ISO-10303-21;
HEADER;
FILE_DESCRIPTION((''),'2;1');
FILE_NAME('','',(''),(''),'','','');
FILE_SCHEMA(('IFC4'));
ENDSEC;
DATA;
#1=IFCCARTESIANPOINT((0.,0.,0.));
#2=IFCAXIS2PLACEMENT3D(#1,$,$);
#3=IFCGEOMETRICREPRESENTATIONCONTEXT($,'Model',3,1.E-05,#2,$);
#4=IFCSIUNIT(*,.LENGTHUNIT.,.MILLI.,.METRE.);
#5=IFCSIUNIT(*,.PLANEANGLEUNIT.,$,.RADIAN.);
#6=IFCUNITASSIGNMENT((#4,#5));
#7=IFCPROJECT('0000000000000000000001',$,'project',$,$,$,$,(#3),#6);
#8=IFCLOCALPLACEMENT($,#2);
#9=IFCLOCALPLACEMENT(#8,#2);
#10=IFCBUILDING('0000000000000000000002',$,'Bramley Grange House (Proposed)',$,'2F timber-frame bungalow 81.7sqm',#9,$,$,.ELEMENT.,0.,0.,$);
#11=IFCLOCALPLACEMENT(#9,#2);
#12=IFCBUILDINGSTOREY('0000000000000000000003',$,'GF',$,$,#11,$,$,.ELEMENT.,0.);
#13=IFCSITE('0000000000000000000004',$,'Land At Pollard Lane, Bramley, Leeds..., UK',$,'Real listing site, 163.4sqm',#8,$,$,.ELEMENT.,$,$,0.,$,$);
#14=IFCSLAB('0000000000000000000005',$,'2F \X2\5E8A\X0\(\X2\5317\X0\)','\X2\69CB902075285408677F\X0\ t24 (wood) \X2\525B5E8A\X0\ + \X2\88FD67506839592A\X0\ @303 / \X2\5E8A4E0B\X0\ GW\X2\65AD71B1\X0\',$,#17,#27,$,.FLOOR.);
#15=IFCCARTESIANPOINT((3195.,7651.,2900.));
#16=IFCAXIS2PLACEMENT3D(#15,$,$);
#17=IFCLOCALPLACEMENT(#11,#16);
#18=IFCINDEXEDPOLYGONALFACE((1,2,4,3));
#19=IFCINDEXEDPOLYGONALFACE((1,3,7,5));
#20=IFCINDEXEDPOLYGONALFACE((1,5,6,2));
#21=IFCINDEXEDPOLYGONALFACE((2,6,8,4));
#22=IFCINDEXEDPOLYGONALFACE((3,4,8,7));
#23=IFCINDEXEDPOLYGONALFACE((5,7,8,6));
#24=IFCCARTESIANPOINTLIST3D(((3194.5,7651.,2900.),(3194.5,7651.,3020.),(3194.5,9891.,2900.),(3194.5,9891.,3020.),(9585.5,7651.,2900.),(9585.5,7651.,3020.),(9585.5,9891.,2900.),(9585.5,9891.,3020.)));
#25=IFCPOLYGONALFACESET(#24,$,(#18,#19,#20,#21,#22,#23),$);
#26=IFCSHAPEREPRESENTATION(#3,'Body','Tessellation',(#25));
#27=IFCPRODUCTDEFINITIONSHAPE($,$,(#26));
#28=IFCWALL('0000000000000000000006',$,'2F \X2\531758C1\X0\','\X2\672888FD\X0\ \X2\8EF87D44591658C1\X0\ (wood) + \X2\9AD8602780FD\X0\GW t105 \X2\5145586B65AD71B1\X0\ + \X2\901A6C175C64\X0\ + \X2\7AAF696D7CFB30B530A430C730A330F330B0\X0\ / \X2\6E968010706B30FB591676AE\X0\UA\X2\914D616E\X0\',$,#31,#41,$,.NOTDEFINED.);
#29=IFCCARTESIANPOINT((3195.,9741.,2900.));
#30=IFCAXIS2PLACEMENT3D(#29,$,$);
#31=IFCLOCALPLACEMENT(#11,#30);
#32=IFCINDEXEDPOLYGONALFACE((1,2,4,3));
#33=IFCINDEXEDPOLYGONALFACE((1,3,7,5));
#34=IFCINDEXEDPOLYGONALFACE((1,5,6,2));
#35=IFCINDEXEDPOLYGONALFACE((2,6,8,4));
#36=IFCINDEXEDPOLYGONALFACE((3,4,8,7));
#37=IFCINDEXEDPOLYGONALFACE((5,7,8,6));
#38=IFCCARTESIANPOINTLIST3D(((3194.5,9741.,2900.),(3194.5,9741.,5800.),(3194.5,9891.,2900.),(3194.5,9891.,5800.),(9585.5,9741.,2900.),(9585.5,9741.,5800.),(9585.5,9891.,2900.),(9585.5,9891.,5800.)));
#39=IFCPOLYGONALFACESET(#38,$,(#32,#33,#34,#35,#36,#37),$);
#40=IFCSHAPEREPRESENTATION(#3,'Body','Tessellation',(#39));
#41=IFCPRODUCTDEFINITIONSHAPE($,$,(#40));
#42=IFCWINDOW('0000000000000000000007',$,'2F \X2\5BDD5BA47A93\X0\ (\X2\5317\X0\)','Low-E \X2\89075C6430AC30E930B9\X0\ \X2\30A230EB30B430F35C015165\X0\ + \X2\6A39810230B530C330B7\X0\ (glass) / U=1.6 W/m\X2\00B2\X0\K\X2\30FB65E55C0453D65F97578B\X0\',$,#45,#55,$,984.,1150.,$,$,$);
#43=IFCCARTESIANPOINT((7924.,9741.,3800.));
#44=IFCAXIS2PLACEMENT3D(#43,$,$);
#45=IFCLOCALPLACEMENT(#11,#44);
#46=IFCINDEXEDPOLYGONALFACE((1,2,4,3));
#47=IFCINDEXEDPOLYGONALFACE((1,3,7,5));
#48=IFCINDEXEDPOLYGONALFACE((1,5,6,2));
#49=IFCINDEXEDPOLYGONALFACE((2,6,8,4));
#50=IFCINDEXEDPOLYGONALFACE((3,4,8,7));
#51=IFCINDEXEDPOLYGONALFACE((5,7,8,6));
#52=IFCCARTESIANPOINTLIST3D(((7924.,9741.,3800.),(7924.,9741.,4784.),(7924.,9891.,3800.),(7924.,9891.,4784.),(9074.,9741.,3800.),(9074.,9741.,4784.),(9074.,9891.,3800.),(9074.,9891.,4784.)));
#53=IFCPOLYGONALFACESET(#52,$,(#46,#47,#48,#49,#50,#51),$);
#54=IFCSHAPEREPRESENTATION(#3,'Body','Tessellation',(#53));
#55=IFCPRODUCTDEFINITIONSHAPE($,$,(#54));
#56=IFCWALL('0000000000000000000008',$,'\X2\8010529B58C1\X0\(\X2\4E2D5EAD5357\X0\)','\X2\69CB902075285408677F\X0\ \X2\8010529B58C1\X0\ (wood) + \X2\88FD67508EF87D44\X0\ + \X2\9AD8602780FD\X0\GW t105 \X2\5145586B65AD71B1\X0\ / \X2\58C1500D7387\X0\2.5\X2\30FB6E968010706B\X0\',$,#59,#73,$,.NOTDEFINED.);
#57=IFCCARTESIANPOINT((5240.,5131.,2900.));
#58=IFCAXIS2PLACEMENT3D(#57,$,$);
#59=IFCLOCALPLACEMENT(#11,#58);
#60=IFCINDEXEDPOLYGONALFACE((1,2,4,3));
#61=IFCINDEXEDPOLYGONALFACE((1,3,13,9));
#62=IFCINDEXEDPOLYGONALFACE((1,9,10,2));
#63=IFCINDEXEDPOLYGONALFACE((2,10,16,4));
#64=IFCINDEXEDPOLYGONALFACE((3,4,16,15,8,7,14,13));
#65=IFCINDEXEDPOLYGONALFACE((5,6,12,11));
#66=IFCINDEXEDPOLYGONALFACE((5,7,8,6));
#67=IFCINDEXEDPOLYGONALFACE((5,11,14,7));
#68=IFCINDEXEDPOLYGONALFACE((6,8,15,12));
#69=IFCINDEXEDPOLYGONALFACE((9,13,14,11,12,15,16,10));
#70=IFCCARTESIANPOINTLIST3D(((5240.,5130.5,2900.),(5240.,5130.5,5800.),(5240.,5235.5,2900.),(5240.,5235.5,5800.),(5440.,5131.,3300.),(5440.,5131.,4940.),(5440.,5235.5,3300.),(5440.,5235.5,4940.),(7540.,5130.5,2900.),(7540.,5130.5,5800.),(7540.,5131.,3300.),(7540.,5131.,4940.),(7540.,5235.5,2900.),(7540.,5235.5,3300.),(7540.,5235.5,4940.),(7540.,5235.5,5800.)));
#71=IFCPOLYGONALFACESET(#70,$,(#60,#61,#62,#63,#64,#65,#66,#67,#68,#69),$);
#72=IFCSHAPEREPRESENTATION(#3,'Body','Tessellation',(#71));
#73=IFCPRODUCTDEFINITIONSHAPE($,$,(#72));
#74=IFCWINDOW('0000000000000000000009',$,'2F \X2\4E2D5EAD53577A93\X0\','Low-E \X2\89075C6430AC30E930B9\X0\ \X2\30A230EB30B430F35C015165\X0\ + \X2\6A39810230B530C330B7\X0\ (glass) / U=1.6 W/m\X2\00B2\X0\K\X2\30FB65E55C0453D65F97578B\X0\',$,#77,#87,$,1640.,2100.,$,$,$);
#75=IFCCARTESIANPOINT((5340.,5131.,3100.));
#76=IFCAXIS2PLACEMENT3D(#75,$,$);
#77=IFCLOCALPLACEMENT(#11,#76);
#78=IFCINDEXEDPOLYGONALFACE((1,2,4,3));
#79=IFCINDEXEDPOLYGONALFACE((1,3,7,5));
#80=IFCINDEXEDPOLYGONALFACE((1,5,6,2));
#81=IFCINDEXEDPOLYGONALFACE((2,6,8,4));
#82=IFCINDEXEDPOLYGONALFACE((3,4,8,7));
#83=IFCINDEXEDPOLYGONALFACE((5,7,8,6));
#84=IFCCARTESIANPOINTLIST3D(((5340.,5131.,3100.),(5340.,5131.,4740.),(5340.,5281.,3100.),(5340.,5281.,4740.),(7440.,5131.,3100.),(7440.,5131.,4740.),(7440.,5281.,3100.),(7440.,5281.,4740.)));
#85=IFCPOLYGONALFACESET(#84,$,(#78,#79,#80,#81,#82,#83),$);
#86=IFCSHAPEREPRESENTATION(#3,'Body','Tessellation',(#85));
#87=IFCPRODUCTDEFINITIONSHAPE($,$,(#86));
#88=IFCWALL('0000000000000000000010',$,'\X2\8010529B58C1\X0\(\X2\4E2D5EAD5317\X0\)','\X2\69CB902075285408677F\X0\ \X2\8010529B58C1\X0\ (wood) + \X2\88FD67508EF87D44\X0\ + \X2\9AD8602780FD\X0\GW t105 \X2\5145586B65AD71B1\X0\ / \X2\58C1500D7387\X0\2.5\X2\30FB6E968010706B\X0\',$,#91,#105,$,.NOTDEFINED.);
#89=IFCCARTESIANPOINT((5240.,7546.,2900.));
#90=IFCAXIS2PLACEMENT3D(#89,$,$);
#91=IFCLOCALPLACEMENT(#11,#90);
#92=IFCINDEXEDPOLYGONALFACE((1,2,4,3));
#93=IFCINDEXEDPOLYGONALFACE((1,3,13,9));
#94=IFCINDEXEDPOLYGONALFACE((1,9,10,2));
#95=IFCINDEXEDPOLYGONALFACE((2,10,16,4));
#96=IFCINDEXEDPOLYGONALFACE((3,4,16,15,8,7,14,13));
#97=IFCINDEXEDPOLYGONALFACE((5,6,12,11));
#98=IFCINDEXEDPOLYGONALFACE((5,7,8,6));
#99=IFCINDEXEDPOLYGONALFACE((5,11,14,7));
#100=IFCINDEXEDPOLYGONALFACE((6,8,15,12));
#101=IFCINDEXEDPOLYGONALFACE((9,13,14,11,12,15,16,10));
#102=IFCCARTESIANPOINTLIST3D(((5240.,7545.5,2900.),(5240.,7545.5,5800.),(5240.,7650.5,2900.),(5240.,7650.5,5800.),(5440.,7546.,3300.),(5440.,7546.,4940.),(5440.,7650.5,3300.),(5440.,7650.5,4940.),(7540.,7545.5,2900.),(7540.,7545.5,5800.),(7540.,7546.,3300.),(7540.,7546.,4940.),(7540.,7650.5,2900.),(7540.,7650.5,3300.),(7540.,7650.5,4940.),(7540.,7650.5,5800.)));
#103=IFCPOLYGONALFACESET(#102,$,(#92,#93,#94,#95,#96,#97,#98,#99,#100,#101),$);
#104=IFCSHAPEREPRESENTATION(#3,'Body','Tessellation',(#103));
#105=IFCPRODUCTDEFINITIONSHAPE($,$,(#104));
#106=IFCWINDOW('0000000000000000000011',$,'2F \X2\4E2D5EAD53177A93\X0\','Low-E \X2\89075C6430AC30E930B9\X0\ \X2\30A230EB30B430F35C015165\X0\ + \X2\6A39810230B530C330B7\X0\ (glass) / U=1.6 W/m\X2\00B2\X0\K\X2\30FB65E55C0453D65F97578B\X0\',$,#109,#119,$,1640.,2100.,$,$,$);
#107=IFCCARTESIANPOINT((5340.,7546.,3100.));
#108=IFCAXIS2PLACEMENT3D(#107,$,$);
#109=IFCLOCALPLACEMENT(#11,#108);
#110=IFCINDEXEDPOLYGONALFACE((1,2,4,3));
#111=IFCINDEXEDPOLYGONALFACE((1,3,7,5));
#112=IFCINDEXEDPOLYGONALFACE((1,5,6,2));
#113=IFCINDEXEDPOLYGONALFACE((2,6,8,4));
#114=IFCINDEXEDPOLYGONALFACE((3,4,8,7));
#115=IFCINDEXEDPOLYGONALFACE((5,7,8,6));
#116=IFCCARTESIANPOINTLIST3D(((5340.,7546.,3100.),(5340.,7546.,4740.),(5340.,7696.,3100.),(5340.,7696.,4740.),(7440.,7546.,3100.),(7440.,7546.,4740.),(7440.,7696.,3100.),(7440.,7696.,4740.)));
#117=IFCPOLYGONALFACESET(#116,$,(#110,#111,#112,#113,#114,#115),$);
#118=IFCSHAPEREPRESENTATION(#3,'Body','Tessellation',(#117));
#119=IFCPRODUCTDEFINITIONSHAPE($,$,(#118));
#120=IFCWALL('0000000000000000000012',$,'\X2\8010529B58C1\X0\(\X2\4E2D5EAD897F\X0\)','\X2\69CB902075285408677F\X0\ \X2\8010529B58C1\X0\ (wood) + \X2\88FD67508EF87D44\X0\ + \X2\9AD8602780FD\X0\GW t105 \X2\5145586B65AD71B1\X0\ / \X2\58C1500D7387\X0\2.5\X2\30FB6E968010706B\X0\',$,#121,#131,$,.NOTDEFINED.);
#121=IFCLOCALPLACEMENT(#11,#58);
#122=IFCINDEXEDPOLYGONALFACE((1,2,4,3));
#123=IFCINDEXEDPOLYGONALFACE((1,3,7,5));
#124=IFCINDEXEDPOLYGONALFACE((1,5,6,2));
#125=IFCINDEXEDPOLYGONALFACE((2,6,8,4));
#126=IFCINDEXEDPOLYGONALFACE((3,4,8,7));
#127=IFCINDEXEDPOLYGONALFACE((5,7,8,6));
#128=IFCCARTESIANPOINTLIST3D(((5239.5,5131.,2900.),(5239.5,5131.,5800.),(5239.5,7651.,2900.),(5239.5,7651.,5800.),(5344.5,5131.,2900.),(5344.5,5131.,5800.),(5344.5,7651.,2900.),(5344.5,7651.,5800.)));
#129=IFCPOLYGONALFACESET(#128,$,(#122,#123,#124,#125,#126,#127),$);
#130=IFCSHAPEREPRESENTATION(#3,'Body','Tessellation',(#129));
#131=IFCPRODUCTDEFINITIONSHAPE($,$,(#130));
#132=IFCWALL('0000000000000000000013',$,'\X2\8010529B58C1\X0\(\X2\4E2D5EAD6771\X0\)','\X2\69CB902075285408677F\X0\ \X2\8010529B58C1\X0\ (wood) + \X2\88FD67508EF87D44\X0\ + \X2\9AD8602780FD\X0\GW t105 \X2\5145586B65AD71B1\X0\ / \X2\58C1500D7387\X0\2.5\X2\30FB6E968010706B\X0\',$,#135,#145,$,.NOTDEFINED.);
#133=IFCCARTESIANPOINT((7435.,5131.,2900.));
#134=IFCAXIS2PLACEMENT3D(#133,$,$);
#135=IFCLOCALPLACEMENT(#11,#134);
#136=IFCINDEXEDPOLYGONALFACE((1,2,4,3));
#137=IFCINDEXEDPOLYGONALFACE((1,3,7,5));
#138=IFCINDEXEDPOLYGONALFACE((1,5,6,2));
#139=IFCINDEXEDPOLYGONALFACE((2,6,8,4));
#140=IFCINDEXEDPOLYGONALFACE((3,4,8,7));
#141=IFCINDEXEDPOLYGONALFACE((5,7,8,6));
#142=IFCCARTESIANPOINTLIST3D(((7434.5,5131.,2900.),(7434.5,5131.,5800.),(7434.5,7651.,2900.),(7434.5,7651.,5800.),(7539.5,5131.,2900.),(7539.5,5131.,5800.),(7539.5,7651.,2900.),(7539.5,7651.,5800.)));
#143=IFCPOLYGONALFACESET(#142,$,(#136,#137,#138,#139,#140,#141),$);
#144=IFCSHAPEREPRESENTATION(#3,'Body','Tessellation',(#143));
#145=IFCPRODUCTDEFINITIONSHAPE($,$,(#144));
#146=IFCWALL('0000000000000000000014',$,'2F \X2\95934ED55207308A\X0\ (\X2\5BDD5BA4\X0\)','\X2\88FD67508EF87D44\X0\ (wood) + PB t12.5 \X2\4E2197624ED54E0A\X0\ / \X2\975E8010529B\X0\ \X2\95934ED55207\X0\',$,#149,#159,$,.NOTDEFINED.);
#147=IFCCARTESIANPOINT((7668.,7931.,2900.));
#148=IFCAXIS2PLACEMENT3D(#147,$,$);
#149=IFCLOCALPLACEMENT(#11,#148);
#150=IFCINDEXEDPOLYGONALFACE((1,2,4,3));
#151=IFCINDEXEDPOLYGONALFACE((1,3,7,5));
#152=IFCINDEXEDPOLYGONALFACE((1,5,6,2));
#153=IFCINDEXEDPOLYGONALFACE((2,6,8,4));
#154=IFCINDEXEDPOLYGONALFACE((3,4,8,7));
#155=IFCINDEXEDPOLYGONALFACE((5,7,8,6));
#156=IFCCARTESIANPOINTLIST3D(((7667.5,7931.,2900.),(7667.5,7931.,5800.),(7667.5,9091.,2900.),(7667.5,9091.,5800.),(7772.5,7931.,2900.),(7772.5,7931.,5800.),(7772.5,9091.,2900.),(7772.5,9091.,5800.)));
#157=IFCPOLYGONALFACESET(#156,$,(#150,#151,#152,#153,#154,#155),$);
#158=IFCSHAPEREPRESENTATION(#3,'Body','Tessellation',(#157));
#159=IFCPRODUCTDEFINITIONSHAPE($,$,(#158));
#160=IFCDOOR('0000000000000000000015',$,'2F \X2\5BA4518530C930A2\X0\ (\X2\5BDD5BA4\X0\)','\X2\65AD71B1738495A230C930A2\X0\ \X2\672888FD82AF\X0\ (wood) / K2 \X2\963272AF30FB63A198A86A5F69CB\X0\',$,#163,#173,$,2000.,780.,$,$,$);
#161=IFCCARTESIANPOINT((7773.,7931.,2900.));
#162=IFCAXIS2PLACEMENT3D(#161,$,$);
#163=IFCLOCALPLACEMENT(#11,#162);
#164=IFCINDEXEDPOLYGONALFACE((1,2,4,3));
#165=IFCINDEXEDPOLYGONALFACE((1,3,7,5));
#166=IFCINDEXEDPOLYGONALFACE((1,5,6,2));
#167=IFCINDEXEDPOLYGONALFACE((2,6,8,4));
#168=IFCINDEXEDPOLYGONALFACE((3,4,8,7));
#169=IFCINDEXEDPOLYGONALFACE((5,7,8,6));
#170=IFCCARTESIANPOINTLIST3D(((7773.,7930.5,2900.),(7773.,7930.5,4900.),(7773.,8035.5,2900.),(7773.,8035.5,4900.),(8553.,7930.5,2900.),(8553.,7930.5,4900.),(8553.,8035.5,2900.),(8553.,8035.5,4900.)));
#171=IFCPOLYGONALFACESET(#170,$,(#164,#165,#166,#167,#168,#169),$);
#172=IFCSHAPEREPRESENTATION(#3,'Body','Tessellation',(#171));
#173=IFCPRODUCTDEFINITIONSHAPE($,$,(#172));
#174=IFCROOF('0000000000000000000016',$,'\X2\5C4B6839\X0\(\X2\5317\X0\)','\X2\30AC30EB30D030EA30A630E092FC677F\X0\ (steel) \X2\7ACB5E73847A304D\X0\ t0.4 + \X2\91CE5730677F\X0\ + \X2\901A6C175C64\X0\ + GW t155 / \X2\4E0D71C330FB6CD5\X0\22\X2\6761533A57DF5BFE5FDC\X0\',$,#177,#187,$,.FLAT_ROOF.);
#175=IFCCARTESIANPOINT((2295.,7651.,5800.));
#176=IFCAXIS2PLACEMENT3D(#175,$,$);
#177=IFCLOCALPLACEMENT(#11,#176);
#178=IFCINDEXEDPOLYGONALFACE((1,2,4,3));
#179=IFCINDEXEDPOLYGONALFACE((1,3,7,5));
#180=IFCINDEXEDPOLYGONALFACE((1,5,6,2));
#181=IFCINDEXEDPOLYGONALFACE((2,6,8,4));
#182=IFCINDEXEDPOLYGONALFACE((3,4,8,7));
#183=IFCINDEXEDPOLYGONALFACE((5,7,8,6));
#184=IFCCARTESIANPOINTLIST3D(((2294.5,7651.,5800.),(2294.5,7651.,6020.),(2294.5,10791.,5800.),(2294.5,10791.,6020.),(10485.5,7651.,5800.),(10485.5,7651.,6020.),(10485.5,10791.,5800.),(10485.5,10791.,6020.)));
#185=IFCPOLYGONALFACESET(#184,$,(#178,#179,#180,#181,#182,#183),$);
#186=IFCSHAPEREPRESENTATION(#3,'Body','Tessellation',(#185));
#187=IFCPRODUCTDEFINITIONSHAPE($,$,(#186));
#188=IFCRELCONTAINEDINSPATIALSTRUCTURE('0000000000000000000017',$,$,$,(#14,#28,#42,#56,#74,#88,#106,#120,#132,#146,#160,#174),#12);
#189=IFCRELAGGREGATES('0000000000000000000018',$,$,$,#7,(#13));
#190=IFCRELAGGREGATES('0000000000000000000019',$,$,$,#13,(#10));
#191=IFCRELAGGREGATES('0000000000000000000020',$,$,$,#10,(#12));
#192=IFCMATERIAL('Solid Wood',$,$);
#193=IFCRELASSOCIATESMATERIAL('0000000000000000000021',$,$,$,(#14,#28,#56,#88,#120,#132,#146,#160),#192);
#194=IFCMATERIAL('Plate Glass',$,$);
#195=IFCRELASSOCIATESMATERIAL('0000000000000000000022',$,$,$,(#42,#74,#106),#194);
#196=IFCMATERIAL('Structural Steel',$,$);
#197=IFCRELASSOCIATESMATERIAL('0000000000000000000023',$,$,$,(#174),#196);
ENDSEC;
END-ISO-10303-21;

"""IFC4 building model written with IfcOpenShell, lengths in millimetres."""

from ifc_helpers import new_model, si_unit, frame, frame_2d, origin, place, context, project, spatial, rectangle, extrude, material, element, fill, save


model = new_model("IFC4")

# Units and contexts
model_context = context("Model", 3, precision=1e-05, world=origin())
ifc_project = project(units=[si_unit("LENGTHUNIT", "METRE", prefix="MILLI"), si_unit("PLANEANGLEUNIT", "RADIAN")], contexts=[model_context])

# Site, building, storey
site_placement = place(None, origin())
site = spatial("IfcSite", under=ifc_project, at=site_placement, Name="Land At Pollard Lane, Bramley, Leeds..., UK", ObjectType="Real listing site, 163.4sqm", CompositionType="ELEMENT", RefElevation=0.0)
building_placement = place(site_placement, origin())
building = spatial("IfcBuilding", under=site, at=building_placement, Name="Bramley Grange House (Proposed)", ObjectType="2F timber-frame bungalow 81.7sqm", CompositionType="ELEMENT", ElevationOfRefHeight=0.0, ElevationOfTerrain=0.0)
storey_placement = place(building_placement, origin())
storey = spatial("IfcBuildingStorey", under=building, at=storey_placement, Name="GF", CompositionType="ELEMENT", Elevation=0.0)

# Slab
ifc_material_1 = material(Name="Solid Wood")
slab_placement = place(storey_placement, frame((3195.0, 7651.0, 2900.0)))
element("IfcSlab", 1, at=slab_placement, inside=storey, material=ifc_material_1, Name="2F 床(北)", Description="構造用合板 t24 (wood) 剛床 + 製材根太 @303 / 床下 GW断熱", PredefinedType="FLOOR", context=model_context, shape_type="SweptSolid", body=[
    extrude(rectangle(XDim=6391.0, YDim=2240.0, at=frame_2d((3195.0, 1120.0))), frame((3195.0, 7651.0, 2900.0)), (0.0, 0.0, 1.0), 120.0),
])

# Walls, openings, windows
wall_1_placement = place(storey_placement, frame((3195.0, 9741.0, 2900.0)))
wall_1 = element("IfcWall", 2, at=wall_1_placement, inside=storey, material=ifc_material_1, Name="2F 北壁", Description="木製 軸組外壁 (wood) + 高性能GW t105 充填断熱 + 通気層 + 窯業系サイディング / 準耐火・外皮UA配慮", PredefinedType="NOTDEFINED", context=model_context, shape_type="SweptSolid", body=[
    extrude(rectangle(XDim=6391.0, YDim=150.0, at=frame_2d((3195.0, 75.0))), frame((3195.0, 9741.0, 2900.0)), (0.0, 0.0, 1.0), 2900.0),
])
opening_1_placement = place(storey_placement, frame((7924.0, 9741.0, 3800.0)))
opening_1 = element("IfcOpeningElement", 3, at=opening_1_placement, cuts=wall_1, PredefinedType="NOTDEFINED", context=model_context, shape_type="SweptSolid", body=[
    extrude(rectangle(XDim=1150.0, YDim=150.0, at=frame_2d((575.0, 75.0))), frame((7924.0, 9741.0, 3800.0)), (0.0, 0.0, 1.0), 984.0),
])
ifc_material_2 = material(Name="Plate Glass")
window_1_placement = place(storey_placement, frame((7924.0, 9741.0, 3800.0)))
window_1 = element("IfcWindow", 4, at=window_1_placement, inside=storey, material=ifc_material_2, Name="2F 寝室窓 (北)", Description="Low-E 複層ガラス アルゴン封入 + 樹脂サッシ (glass) / U=1.6 W/m²K・日射取得型", OverallHeight=984.0, OverallWidth=1150.0, context=model_context, shape_type="SweptSolid", body=[
    extrude(rectangle(XDim=1150.0, YDim=150.0, at=frame_2d((575.0, 75.0))), frame((7924.0, 9741.0, 3800.0)), (0.0, 0.0, 1.0), 984.0),
])
fill(opening_1, window_1)
wall_2_placement = place(storey_placement, frame((5240.0, 5131.0, 2900.0)))
wall_2 = element("IfcWall", 5, at=wall_2_placement, inside=storey, material=ifc_material_1, Name="耐力壁(中庭南)", Description="構造用合板 耐力壁 (wood) + 製材軸組 + 高性能GW t105 充填断熱 / 壁倍率2.5・準耐火", PredefinedType="NOTDEFINED", context=model_context, shape_type="SweptSolid", body=[
    extrude(rectangle(XDim=2300.0, YDim=105.0, at=frame_2d((1150.0, 52.0))), frame((5240.0, 5131.0, 2900.0)), (0.0, 0.0, 1.0), 2900.0),
])
opening_2_placement = place(storey_placement, frame((5340.0, 5131.0, 3100.0)))
opening_2 = element("IfcOpeningElement", 6, at=opening_2_placement, cuts=wall_2, PredefinedType="NOTDEFINED", context=model_context, shape_type="SweptSolid", body=[
    extrude(rectangle(XDim=2100.0, YDim=150.0, at=frame_2d((1050.0, 75.0))), frame((5340.0, 5131.0, 3100.0)), (0.0, 0.0, 1.0), 1640.0),
])
window_2_placement = place(storey_placement, frame((5340.0, 5131.0, 3100.0)))
window_2 = element("IfcWindow", 7, at=window_2_placement, inside=storey, material=ifc_material_2, Name="2F 中庭南窓", Description="Low-E 複層ガラス アルゴン封入 + 樹脂サッシ (glass) / U=1.6 W/m²K・日射取得型", OverallHeight=1640.0, OverallWidth=2100.0, context=model_context, shape_type="SweptSolid", body=[
    extrude(rectangle(XDim=2100.0, YDim=150.0, at=frame_2d((1050.0, 75.0))), frame((5340.0, 5131.0, 3100.0)), (0.0, 0.0, 1.0), 1640.0),
])
fill(opening_2, window_2)
wall_3_placement = place(storey_placement, frame((5240.0, 7546.0, 2900.0)))
wall_3 = element("IfcWall", 8, at=wall_3_placement, inside=storey, material=ifc_material_1, Name="耐力壁(中庭北)", Description="構造用合板 耐力壁 (wood) + 製材軸組 + 高性能GW t105 充填断熱 / 壁倍率2.5・準耐火", PredefinedType="NOTDEFINED", context=model_context, shape_type="SweptSolid", body=[
    extrude(rectangle(XDim=2300.0, YDim=105.0, at=frame_2d((1150.0, 52.0))), frame((5240.0, 7546.0, 2900.0)), (0.0, 0.0, 1.0), 2900.0),
])
opening_3_placement = place(storey_placement, frame((5340.0, 7546.0, 3100.0)))
opening_3 = element("IfcOpeningElement", 9, at=opening_3_placement, cuts=wall_3, PredefinedType="NOTDEFINED", context=model_context, shape_type="SweptSolid", body=[
    extrude(rectangle(XDim=2100.0, YDim=150.0, at=frame_2d((1050.0, 75.0))), frame((5340.0, 7546.0, 3100.0)), (0.0, 0.0, 1.0), 1640.0),
])
window_3_placement = place(storey_placement, frame((5340.0, 7546.0, 3100.0)))
window_3 = element("IfcWindow", 10, at=window_3_placement, inside=storey, material=ifc_material_2, Name="2F 中庭北窓", Description="Low-E 複層ガラス アルゴン封入 + 樹脂サッシ (glass) / U=1.6 W/m²K・日射取得型", OverallHeight=1640.0, OverallWidth=2100.0, context=model_context, shape_type="SweptSolid", body=[
    extrude(rectangle(XDim=2100.0, YDim=150.0, at=frame_2d((1050.0, 75.0))), frame((5340.0, 7546.0, 3100.0)), (0.0, 0.0, 1.0), 1640.0),
])
fill(opening_3, window_3)

# Walls
wall_4_placement = place(storey_placement, frame((5240.0, 5131.0, 2900.0)))
element("IfcWall", 11, at=wall_4_placement, inside=storey, material=ifc_material_1, Name="耐力壁(中庭西)", Description="構造用合板 耐力壁 (wood) + 製材軸組 + 高性能GW t105 充填断熱 / 壁倍率2.5・準耐火", PredefinedType="NOTDEFINED", context=model_context, shape_type="SweptSolid", body=[
    extrude(rectangle(XDim=105.0, YDim=2520.0, at=frame_2d((52.0, 1260.0))), frame((5240.0, 5131.0, 2900.0)), (0.0, 0.0, 1.0), 2900.0),
])
wall_5_placement = place(storey_placement, frame((7435.0, 5131.0, 2900.0)))
element("IfcWall", 12, at=wall_5_placement, inside=storey, material=ifc_material_1, Name="耐力壁(中庭東)", Description="構造用合板 耐力壁 (wood) + 製材軸組 + 高性能GW t105 充填断熱 / 壁倍率2.5・準耐火", PredefinedType="NOTDEFINED", context=model_context, shape_type="SweptSolid", body=[
    extrude(rectangle(XDim=105.0, YDim=2520.0, at=frame_2d((52.0, 1260.0))), frame((7435.0, 5131.0, 2900.0)), (0.0, 0.0, 1.0), 2900.0),
])
wall_6_placement = place(storey_placement, frame((7668.0, 7931.0, 2900.0)))
element("IfcWall", 13, at=wall_6_placement, inside=storey, material=ifc_material_1, Name="2F 間仕切り (寝室)", Description="製材軸組 (wood) + PB t12.5 両面仕上 / 非耐力 間仕切", PredefinedType="NOTDEFINED", context=model_context, shape_type="SweptSolid", body=[
    extrude(rectangle(XDim=105.0, YDim=1160.0, at=frame_2d((52.0, 580.0))), frame((7668.0, 7931.0, 2900.0)), (0.0, 0.0, 1.0), 2900.0),
])

# Door
door_placement = place(storey_placement, frame((7773.0, 7931.0, 2900.0)))
element("IfcDoor", 14, at=door_placement, inside=storey, material=ifc_material_1, Name="2F 室内ドア (寝室)", Description="断熱玄関ドア 木製芯 (wood) / K2 防犯・採風機構", OverallHeight=2000.0, OverallWidth=780.0, context=model_context, shape_type="SweptSolid", body=[
    extrude(rectangle(XDim=780.0, YDim=105.0, at=frame_2d((390.0, 52.0))), frame((7773.0, 7931.0, 2900.0)), (0.0, 0.0, 1.0), 2000.0),
])

# Roof
ifc_material_3 = material(Name="Structural Steel")
for number, where, name in (
    (15, (2295.0, 7651.0, 5800.0), "屋根(北)"),
):
    element("IfcRoof", number, at=place(storey_placement, frame(where)), inside=storey, material=ifc_material_3, Name=name, Description="ガルバリウム鋼板 (steel) 立平葺き t0.4 + 野地板 + 通気層 + GW t155 / 不燃・法22条区域対応", PredefinedType="FLAT_ROOF", context=model_context, shape_type="SweptSolid", body=[
        extrude(rectangle(XDim=8191.0, YDim=3140.0, at=frame_2d((4095.0, 1570.0))), frame((2295.0, 7651.0, 5800.0)), (0.0, 0.0, 1.0), 220.0),
    ])

save(model, "model.ifc")
